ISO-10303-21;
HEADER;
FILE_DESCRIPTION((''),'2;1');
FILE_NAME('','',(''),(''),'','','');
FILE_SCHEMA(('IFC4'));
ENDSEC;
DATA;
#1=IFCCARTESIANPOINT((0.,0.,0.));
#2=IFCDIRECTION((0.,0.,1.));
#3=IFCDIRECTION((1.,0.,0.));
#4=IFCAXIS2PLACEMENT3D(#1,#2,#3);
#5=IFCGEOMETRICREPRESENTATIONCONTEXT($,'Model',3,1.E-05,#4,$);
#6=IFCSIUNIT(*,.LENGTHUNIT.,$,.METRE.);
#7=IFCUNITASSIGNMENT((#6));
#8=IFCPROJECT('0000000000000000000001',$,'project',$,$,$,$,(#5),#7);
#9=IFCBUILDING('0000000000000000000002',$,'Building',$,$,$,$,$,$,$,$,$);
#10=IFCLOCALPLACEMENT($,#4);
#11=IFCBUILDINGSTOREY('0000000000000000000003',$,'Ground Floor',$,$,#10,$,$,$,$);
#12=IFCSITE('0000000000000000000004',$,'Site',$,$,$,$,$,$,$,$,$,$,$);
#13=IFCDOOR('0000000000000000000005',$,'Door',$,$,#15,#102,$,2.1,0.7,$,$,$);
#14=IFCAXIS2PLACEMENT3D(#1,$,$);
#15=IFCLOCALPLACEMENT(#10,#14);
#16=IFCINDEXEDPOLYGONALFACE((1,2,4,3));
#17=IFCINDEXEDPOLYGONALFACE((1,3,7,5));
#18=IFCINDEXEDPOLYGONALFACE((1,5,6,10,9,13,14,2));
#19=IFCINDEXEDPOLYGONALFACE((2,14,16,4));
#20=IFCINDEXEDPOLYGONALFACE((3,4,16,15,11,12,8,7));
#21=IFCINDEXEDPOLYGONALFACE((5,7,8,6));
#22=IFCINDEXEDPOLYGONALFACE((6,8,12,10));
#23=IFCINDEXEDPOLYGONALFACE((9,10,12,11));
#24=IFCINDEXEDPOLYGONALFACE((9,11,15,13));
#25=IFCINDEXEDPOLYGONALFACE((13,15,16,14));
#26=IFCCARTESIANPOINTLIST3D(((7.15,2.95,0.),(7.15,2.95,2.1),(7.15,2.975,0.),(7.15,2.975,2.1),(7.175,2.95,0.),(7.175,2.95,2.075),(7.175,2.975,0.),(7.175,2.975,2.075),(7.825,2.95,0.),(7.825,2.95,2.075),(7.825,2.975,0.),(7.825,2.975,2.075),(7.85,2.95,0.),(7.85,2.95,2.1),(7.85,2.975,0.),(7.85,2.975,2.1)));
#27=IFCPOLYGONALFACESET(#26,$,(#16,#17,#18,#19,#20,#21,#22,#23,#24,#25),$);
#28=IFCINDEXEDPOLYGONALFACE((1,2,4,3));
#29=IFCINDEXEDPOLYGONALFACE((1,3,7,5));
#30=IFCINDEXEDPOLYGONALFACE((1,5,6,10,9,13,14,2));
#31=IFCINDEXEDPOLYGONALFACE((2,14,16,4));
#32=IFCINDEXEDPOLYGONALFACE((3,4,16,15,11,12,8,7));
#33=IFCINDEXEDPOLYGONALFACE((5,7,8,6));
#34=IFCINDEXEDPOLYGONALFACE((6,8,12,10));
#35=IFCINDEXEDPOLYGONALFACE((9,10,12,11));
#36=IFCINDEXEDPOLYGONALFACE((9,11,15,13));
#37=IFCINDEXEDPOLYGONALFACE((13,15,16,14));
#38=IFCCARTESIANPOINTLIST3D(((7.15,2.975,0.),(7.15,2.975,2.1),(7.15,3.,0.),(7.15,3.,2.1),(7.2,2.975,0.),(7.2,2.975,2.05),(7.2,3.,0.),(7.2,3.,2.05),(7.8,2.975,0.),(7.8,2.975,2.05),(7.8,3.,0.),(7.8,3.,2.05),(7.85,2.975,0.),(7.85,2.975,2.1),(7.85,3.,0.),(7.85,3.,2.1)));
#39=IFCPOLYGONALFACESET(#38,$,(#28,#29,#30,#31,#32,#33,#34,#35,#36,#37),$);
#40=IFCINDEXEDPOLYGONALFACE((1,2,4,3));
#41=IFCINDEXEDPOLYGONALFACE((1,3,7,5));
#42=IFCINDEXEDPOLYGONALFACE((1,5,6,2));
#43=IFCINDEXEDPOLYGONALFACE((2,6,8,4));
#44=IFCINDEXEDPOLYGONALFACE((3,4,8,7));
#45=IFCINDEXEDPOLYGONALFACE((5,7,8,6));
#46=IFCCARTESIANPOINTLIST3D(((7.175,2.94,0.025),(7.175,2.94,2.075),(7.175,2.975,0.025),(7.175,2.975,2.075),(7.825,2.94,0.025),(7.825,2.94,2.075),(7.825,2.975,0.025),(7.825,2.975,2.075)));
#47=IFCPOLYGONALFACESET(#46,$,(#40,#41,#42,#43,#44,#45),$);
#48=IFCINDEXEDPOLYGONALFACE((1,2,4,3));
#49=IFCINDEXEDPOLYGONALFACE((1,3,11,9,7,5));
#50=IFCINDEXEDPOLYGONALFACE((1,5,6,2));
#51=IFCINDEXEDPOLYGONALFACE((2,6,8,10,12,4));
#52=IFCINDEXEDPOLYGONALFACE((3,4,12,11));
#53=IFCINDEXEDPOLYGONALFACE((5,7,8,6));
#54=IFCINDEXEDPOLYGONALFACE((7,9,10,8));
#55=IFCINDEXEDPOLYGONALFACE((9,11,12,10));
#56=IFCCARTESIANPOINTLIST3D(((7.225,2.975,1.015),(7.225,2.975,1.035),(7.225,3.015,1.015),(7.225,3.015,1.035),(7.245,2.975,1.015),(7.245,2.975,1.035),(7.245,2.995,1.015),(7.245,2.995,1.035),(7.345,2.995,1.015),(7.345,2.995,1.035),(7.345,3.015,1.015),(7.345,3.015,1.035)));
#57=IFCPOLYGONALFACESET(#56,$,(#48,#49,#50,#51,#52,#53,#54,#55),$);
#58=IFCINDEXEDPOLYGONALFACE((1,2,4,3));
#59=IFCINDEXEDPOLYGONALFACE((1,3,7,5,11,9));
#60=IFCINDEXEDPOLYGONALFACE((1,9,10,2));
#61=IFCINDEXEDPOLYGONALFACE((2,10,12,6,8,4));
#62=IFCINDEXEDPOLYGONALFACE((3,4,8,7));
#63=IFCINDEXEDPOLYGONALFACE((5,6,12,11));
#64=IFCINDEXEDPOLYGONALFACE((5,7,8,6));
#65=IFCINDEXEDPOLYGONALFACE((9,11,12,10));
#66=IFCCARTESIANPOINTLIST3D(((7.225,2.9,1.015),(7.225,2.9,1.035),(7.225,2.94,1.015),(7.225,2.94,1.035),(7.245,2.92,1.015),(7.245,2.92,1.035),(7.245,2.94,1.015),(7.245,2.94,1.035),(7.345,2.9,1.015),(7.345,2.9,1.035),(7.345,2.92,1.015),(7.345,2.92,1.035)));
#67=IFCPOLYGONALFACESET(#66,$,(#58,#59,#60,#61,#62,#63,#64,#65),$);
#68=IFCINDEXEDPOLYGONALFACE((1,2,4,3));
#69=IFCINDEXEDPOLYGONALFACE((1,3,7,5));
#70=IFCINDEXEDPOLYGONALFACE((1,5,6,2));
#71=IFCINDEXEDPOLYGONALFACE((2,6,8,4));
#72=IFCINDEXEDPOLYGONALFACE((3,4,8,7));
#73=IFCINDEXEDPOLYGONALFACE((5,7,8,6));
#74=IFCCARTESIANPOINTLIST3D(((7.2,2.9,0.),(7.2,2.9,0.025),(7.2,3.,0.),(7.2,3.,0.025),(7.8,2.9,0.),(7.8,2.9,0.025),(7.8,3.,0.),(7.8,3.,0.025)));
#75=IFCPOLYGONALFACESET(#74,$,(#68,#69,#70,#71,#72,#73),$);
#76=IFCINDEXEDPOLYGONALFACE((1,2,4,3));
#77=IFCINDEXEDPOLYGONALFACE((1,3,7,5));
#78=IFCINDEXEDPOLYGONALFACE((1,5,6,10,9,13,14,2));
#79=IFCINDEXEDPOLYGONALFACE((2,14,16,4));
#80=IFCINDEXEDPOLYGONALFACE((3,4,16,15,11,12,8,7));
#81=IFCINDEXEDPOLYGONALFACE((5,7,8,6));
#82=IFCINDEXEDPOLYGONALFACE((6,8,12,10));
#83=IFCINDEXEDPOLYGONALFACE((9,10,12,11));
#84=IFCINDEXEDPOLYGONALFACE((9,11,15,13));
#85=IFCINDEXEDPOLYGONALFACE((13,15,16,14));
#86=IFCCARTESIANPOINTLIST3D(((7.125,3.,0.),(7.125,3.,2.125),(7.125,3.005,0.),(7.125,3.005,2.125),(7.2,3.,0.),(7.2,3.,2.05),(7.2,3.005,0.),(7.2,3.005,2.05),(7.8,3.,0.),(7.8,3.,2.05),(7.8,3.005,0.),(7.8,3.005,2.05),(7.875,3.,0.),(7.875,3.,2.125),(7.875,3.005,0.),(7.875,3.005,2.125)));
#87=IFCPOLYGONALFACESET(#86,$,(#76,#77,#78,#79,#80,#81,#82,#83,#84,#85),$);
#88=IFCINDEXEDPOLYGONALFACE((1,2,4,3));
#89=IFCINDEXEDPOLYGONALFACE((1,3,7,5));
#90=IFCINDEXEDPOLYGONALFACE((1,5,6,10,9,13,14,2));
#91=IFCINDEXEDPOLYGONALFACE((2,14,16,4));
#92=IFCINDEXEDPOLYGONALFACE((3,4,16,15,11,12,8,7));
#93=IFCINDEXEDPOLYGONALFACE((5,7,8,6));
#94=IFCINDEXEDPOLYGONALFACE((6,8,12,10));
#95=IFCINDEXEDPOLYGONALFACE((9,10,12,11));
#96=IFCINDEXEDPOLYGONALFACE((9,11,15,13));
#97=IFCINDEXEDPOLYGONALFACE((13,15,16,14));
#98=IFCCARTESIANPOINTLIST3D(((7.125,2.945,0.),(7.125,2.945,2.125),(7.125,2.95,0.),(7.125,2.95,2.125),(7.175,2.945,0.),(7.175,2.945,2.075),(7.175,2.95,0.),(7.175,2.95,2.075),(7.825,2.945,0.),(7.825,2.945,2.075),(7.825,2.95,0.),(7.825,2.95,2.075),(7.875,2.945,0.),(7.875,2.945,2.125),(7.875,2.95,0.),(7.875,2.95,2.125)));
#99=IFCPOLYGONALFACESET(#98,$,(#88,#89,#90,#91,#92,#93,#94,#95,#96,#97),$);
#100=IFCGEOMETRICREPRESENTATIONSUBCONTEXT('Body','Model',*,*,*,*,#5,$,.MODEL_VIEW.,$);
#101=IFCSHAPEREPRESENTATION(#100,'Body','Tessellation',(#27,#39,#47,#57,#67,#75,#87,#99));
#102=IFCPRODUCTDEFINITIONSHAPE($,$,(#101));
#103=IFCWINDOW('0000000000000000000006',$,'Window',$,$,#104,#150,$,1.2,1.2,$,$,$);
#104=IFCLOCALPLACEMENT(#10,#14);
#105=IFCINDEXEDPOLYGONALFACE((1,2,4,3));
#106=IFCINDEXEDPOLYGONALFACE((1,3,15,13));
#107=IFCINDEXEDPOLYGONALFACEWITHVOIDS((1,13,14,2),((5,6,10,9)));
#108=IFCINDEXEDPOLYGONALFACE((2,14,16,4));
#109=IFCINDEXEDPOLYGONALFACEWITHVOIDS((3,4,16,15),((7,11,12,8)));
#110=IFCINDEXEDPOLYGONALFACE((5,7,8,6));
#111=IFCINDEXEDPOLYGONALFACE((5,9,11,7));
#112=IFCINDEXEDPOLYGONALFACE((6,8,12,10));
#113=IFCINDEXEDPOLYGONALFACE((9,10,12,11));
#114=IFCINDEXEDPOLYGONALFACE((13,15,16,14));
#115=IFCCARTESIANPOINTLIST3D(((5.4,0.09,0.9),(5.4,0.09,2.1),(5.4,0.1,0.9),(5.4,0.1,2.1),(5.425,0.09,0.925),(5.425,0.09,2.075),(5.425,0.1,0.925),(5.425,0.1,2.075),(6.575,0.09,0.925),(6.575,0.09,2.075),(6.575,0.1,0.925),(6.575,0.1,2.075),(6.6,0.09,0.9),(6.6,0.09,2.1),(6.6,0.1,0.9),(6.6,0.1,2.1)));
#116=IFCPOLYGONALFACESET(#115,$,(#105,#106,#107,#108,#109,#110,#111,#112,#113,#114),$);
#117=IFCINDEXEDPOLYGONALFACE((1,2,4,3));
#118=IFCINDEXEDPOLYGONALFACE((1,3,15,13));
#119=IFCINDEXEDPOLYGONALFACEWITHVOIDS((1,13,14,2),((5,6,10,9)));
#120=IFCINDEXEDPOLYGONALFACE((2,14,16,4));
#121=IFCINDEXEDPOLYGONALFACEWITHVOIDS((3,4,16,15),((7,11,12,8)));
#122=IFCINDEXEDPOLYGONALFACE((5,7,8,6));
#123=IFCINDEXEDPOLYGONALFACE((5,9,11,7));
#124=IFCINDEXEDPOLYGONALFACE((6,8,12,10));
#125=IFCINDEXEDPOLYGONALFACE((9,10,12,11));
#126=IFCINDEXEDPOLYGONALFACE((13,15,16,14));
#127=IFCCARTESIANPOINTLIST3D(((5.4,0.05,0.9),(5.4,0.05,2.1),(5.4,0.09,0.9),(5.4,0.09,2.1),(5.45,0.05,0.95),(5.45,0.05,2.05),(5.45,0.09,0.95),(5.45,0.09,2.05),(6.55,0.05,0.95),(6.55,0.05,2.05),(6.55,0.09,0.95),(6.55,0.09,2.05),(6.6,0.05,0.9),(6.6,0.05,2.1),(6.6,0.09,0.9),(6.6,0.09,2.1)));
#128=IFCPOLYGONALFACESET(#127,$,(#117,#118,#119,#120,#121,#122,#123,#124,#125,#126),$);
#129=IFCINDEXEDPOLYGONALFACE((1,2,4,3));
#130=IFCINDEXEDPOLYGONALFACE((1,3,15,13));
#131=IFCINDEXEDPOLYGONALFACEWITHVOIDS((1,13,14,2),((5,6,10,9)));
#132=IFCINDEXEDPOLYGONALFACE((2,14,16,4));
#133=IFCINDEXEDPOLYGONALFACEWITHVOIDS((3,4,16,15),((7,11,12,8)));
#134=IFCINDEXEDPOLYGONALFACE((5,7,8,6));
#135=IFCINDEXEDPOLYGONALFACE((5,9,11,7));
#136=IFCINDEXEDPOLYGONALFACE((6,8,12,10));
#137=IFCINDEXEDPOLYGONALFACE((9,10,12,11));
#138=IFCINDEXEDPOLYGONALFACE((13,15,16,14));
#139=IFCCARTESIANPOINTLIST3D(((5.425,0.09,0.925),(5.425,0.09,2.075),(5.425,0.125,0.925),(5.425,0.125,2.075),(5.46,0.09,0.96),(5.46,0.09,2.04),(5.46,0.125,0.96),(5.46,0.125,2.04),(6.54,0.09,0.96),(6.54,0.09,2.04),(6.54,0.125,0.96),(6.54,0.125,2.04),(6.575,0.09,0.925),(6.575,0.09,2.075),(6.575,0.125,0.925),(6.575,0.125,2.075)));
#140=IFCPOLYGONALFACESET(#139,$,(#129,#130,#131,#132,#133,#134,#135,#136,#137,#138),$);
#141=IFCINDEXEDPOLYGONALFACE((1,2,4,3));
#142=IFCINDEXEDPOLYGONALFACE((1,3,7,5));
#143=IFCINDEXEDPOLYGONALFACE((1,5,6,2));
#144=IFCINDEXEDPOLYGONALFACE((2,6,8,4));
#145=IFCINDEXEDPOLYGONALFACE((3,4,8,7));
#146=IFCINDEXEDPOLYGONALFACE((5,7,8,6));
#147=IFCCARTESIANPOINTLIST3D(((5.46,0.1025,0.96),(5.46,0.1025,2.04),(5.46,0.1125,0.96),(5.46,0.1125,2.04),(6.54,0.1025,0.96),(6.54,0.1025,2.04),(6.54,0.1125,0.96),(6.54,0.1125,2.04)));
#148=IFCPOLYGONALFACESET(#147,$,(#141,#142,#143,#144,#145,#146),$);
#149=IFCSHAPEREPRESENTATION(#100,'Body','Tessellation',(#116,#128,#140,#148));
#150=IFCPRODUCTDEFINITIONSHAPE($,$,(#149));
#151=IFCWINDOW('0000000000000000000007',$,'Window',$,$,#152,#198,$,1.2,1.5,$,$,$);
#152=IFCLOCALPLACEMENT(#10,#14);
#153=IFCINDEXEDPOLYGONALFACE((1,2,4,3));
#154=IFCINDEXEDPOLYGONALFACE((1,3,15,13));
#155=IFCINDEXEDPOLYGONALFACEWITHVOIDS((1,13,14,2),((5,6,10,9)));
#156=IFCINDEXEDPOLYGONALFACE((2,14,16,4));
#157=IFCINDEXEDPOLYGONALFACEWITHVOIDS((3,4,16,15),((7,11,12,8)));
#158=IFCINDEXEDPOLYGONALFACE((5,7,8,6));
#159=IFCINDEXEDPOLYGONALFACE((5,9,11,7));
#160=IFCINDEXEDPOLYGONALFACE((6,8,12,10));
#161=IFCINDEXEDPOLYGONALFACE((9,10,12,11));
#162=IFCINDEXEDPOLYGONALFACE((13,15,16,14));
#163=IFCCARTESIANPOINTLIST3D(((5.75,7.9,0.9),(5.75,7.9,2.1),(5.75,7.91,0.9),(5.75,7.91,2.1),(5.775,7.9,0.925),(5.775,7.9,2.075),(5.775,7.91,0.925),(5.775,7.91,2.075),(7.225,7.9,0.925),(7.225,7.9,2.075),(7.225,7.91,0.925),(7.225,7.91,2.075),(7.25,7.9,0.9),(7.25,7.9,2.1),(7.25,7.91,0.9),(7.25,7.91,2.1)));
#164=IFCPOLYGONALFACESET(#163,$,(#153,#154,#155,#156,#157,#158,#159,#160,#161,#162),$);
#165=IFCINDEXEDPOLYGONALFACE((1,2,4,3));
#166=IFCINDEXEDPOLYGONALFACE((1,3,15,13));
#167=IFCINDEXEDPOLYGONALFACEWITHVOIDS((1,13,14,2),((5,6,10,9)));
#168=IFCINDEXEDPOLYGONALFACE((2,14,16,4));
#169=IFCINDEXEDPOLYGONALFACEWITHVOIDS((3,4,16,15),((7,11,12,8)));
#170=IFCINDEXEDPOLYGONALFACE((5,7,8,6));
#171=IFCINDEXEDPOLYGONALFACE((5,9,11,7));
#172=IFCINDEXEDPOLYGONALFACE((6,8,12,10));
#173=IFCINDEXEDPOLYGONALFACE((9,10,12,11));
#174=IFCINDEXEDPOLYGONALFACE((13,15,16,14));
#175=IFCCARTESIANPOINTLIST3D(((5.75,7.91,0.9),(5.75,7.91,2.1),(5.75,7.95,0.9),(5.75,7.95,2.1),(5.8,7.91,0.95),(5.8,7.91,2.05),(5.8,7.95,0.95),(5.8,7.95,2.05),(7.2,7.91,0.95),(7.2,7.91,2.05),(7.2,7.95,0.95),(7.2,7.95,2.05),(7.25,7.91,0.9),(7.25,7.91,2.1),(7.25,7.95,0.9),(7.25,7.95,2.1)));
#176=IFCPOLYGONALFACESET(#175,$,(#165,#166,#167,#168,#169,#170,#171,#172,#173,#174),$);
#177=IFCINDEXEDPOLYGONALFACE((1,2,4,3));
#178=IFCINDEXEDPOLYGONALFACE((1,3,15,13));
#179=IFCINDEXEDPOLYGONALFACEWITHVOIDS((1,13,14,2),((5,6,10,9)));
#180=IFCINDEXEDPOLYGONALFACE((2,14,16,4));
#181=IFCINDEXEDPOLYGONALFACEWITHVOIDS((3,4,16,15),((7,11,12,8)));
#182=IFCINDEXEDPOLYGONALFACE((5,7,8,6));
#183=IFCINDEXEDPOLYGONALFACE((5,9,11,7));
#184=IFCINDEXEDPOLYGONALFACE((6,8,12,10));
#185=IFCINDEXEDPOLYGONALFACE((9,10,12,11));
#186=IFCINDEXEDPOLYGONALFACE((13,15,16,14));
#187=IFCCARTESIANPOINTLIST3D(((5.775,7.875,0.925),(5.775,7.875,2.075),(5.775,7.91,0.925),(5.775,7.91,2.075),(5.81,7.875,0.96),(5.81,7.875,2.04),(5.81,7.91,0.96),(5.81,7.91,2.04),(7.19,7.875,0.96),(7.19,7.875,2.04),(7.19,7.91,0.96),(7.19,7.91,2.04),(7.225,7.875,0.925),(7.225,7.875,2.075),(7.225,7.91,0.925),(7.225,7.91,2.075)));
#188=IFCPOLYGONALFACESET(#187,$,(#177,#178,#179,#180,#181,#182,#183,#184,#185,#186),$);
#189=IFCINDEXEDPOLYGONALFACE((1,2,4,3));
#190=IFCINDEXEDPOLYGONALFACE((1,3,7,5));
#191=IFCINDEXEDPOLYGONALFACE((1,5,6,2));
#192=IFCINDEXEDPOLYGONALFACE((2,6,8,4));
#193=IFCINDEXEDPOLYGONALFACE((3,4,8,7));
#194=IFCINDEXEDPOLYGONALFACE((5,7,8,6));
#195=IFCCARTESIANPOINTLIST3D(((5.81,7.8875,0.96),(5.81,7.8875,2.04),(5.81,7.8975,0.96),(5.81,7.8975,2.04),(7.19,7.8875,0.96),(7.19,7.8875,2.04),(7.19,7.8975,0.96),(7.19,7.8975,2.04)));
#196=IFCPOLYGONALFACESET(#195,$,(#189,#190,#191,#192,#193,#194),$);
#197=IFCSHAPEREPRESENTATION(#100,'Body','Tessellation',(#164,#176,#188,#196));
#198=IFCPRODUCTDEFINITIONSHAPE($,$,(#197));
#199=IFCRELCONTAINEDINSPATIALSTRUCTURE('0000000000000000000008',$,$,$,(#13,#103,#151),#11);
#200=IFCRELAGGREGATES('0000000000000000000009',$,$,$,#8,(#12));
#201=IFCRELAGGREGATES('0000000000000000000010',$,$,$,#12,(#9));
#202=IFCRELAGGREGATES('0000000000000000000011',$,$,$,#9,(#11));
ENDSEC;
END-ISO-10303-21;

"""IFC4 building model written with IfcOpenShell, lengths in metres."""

from ifc_helpers import new_model, si_unit, frame, origin_with_axes, place, context, subcontext, project, spatial, line, indexed_curve, outline, extrude, element, save


model = new_model("IFC4")

# Units and contexts
model_context = context("Model", 3, precision=1e-05, world=origin_with_axes())
body_context = subcontext(model_context, "Body", "Model", "MODEL_VIEW")
ifc_project = project(units=[si_unit("LENGTHUNIT", "METRE")], contexts=[model_context])

# Site, building, storey
site = spatial("IfcSite", under=ifc_project, Name="Site")
building = spatial("IfcBuilding", under=site, Name="Building")
storey_placement = place(None, origin_with_axes())
storey = spatial("IfcBuildingStorey", under=building, at=storey_placement, Name="Ground Floor")

# Door
door_1_placement = place(storey_placement, frame((7.85, 3.0, 0.0), z_axis=(0.0, 0.0, 1.0), x_axis=(-1.0, 0.0, 0.0)))
element("IfcDoor", 1, at=door_1_placement, inside=storey, Name="Door", OverallHeight=2.1, OverallWidth=0.7, context=body_context, shape_type="SweptSolid", body=[
    extrude(outline(indexed_curve([(0.0, 0.0), (0.0, 2.1), (0.7, 2.1), (0.7, 0.0), (0.675, 0.0), (0.675, 2.075), (0.025, 2.075), (0.025, 0.0)], segments=[line(1, 2, 3, 4, 5, 6, 7, 8, 1)])), frame((0.0, 0.025, 0.0), z_axis=(0.0, -1.0, 0.0), x_axis=(1.0, 0.0, 0.0)), (0.0, 0.0, -1.0), 0.025),
    extrude(outline(indexed_curve([(0.0, 0.0), (0.0, 2.1), (0.7, 2.1), (0.7, 0.0), (0.65, 0.0), (0.65, 2.05), (0.05, 2.05), (0.05, 0.0)], segments=[line(1, 2, 3, 4, 5, 6, 7, 8, 1)])), frame((0.0, 0.0, 0.0), z_axis=(0.0, -1.0, 0.0), x_axis=(1.0, 0.0, 0.0)), (0.0, 0.0, -1.0), 0.025),
    extrude(outline(indexed_curve([(0.0, 0.0), (0.65, 0.0), (0.65, 0.035), (0.0, 0.035)], segments=[line(1, 2, 3, 4, 1)])), frame((0.025, 0.025, 0.025), z_axis=(0.0, 0.0, 1.0), x_axis=(1.0, 0.0, 0.0)), (0.0, 0.0, 1.0), 2.05),
    extrude(outline(indexed_curve([(0.0, 0.0), (0.0, -0.04), (-0.12, -0.04), (-0.12, -0.02), (-0.02, -0.02), (-0.02, 0.0)], segments=[line(1, 2, 3, 4, 5, 6, 1)])), frame((0.625, 0.025, 1.015), z_axis=(0.0, 0.0, 1.0), x_axis=(1.0, 0.0, 0.0)), (0.0, 0.0, 1.0), 0.02),
    extrude(outline(indexed_curve([(0.0, 0.0), (0.0, 0.04), (-0.12, 0.04), (-0.12, 0.02), (-0.02, 0.02), (-0.02, 0.0)], segments=[line(1, 2, 3, 4, 5, 6, 1)])), frame((0.625, 0.06, 1.015), z_axis=(0.0, 0.0, 1.0), x_axis=(1.0, 0.0, 0.0)), (0.0, 0.0, 1.0), 0.02),
    extrude(outline(indexed_curve([(0.0, 0.0), (0.6, 0.0), (0.6, 0.1), (0.0, 0.1)], segments=[line(1, 2, 3, 4, 1)])), frame((0.05, 0.0, 0.0), z_axis=(0.0, 0.0, 1.0), x_axis=(1.0, 0.0, 0.0)), (0.0, 0.0, 1.0), 0.025),
    extrude(outline(indexed_curve([(0.0, 0.0), (0.0, 2.125), (0.75, 2.125), (0.75, 0.0), (0.675, 0.0), (0.675, 2.05), (0.075, 2.05), (0.075, 0.0)], segments=[line(1, 2, 3, 4, 5, 6, 7, 8, 1)])), frame((-0.025, -0.005, 0.0), z_axis=(0.0, -1.0, 0.0), x_axis=(1.0, 0.0, 0.0)), (0.0, 0.0, -1.0), 0.005),
    extrude(outline(indexed_curve([(0.0, 0.0), (0.0, 2.125), (0.75, 2.125), (0.75, 0.0), (0.7, 0.0), (0.7, 2.075), (0.05, 2.075), (0.05, 0.0)], segments=[line(1, 2, 3, 4, 5, 6, 7, 8, 1)])), frame((-0.025, 0.05, 0.0), z_axis=(0.0, -1.0, 0.0), x_axis=(1.0, 0.0, 0.0)), (0.0, 0.0, -1.0), 0.005),
])

# Windows
window_1_placement = place(storey_placement, frame((5.4, 0.0, 0.9), z_axis=(0.0, 0.0, 1.0), x_axis=(1.0, 0.0, 0.0)))
element("IfcWindow", 2, at=window_1_placement, inside=storey, Name="Window", OverallHeight=1.2, OverallWidth=1.2, context=body_context, shape_type="SweptSolid", body=[
    extrude(outline(indexed_curve([(0.0, 0.0), (1.2, 0.0), (1.2, 1.2), (0.0, 1.2)], segments=[line(1, 2, 3, 4, 1)]), holes=[indexed_curve([(0.025, 0.025), (1.175, 0.025), (1.175, 1.175), (0.025, 1.175)], segments=[line(1, 2, 3, 4, 1)])]), frame((0.0, 0.09, 0.0), z_axis=(0.0, -1.0, 0.0), x_axis=(1.0, 0.0, 0.0)), (0.0, 0.0, -1.0), 0.01),
    extrude(outline(indexed_curve([(0.0, 0.0), (1.2, 0.0), (1.2, 1.2), (0.0, 1.2)], segments=[line(1, 2, 3, 4, 1)]), holes=[indexed_curve([(0.05, 0.05), (1.15, 0.05), (1.15, 1.15), (0.05, 1.15)], segments=[line(1, 2, 3, 4, 1)])]), frame((0.0, 0.05, 0.0), z_axis=(0.0, -1.0, 0.0), x_axis=(1.0, 0.0, 0.0)), (0.0, 0.0, -1.0), 0.04),
    extrude(outline(indexed_curve([(0.0, 0.0), (1.15, 0.0), (1.15, 1.15), (0.0, 1.15)], segments=[line(1, 2, 3, 4, 1)]), holes=[indexed_curve([(0.035, 0.035), (1.115, 0.035), (1.115, 1.115), (0.035, 1.115)], segments=[line(1, 2, 3, 4, 1)])]), frame((0.025, 0.09, 0.025), z_axis=(0.0, -1.0, 0.0), x_axis=(1.0, 0.0, 0.0)), (0.0, 0.0, -1.0), 0.035),
    extrude(outline(indexed_curve([(0.035, 0.035), (1.115, 0.035), (1.115, 1.115), (0.035, 1.115)], segments=[line(1, 2, 3, 4, 1)])), frame((0.025, 0.1025, 0.025), z_axis=(0.0, -1.0, 0.0), x_axis=(1.0, 0.0, 0.0)), (0.0, 0.0, -1.0), 0.01),
])
for number, where, z_axis, x_axis, name in (
    (3, (7.25, 8.0, 0.9), (0.0, 0.0, 1.0), (-1.0, 0.0, 0.0), "Window"),
):
    element("IfcWindow", number, at=place(storey_placement, frame(where, z_axis=z_axis, x_axis=x_axis)), inside=storey, Name=name, OverallHeight=1.2, OverallWidth=1.5, context=body_context, shape_type="SweptSolid", body=[
        extrude(outline(indexed_curve([(0.0, 0.0), (1.5, 0.0), (1.5, 1.2), (0.0, 1.2)], segments=[line(1, 2, 3, 4, 1)]), holes=[indexed_curve([(0.025, 0.025), (1.475, 0.025), (1.475, 1.175), (0.025, 1.175)], segments=[line(1, 2, 3, 4, 1)])]), frame((0.0, 0.09, 0.0), z_axis=(0.0, -1.0, 0.0), x_axis=(1.0, 0.0, 0.0)), (0.0, 0.0, -1.0), 0.01),
        extrude(outline(indexed_curve([(0.0, 0.0), (1.5, 0.0), (1.5, 1.2), (0.0, 1.2)], segments=[line(1, 2, 3, 4, 1)]), holes=[indexed_curve([(0.05, 0.05), (1.45, 0.05), (1.45, 1.15), (0.05, 1.15)], segments=[line(1, 2, 3, 4, 1)])]), frame((0.0, 0.05, 0.0), z_axis=(0.0, -1.0, 0.0), x_axis=(1.0, 0.0, 0.0)), (0.0, 0.0, -1.0), 0.04),
        extrude(outline(indexed_curve([(0.0, 0.0), (1.45, 0.0), (1.45, 1.15), (0.0, 1.15)], segments=[line(1, 2, 3, 4, 1)]), holes=[indexed_curve([(0.035, 0.035), (1.415, 0.035), (1.415, 1.115), (0.035, 1.115)], segments=[line(1, 2, 3, 4, 1)])]), frame((0.025, 0.09, 0.025), z_axis=(0.0, -1.0, 0.0), x_axis=(1.0, 0.0, 0.0)), (0.0, 0.0, -1.0), 0.035),
        extrude(outline(indexed_curve([(0.035, 0.035), (1.415, 0.035), (1.415, 1.115), (0.035, 1.115)], segments=[line(1, 2, 3, 4, 1)])), frame((0.025, 0.1025, 0.025), z_axis=(0.0, -1.0, 0.0), x_axis=(1.0, 0.0, 0.0)), (0.0, 0.0, -1.0), 0.01),
    ])

save(model, "model.ifc")
